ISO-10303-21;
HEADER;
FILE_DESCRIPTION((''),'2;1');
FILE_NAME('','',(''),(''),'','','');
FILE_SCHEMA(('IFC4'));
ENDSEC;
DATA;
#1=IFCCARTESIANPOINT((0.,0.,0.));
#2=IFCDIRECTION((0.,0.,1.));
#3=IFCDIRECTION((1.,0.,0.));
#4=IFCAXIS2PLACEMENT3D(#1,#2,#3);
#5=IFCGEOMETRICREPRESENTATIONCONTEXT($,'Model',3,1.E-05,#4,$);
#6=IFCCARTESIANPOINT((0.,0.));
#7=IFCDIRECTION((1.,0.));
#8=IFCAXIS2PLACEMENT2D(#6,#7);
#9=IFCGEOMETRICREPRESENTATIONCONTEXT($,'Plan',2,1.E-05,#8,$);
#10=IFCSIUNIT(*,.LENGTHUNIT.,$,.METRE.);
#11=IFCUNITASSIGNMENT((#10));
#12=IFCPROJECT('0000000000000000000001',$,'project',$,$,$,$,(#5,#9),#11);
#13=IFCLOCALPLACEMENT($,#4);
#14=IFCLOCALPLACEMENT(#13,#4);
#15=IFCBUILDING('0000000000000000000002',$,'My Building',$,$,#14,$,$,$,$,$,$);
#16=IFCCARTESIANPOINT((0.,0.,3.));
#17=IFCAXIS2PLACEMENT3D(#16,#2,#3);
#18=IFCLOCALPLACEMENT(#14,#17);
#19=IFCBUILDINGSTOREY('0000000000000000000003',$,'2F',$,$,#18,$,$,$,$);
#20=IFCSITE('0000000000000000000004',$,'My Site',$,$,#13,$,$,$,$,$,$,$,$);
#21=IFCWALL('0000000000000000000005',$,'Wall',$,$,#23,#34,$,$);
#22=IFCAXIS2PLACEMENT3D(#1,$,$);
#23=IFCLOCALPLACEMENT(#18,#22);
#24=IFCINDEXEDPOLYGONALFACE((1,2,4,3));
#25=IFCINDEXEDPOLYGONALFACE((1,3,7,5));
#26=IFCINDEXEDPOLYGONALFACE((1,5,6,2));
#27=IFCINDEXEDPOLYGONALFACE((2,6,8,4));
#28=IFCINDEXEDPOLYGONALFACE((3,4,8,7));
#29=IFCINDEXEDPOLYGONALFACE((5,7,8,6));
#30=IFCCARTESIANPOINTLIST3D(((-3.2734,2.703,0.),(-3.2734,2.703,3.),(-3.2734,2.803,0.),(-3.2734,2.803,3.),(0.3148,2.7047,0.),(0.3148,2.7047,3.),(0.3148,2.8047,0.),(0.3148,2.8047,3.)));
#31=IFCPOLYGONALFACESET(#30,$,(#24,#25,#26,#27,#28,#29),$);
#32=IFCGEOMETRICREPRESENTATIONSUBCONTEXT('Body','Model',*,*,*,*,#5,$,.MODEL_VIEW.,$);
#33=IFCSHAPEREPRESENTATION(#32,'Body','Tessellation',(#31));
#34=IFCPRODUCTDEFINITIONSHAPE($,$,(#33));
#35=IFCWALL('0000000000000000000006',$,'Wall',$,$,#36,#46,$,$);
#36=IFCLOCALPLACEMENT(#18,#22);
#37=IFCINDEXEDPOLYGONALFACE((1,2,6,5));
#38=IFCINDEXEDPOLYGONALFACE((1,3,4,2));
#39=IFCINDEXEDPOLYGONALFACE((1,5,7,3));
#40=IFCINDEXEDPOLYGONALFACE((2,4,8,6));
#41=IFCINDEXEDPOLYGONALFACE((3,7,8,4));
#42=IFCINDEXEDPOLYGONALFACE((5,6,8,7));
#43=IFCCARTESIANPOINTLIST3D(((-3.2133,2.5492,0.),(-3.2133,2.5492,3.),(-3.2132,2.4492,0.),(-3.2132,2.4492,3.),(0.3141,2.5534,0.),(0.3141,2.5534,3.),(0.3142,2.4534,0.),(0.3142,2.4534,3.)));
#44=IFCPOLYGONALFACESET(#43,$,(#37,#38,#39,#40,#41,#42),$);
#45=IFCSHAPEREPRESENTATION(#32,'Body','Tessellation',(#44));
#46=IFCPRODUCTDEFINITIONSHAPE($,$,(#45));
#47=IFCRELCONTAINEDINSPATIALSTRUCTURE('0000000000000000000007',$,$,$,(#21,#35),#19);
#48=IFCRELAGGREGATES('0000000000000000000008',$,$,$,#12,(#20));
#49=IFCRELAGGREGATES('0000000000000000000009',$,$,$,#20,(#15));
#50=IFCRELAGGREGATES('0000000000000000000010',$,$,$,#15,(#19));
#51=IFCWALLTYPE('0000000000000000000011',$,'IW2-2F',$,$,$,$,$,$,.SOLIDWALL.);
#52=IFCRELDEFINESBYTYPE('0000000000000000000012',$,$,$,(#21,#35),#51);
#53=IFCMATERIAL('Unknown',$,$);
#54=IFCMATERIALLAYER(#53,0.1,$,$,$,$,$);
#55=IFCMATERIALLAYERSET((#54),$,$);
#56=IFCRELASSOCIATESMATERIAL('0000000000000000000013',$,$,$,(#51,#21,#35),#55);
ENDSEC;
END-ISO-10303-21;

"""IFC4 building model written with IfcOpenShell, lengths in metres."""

from ifc_helpers import new_model, si_unit, frame, origin_with_axes, origin_2d_with_axis, place, context, subcontext, project, spatial, line, indexed_curve, outline, extrude, material, layer, layer_set, layer_usage, type_object, element, save


model = new_model("IFC4")

# Units and contexts
model_context = context("Model", 3, precision=1e-05, world=origin_with_axes())
plan_context = context("Plan", 2, precision=1e-05, world=origin_2d_with_axis())
body_context_1 = subcontext(model_context, "Body", "Model", "MODEL_VIEW")
ifc_project = project(units=[si_unit("LENGTHUNIT", "METRE")], contexts=[model_context, plan_context])

# Site, building, storey
site_placement = place(None, origin_with_axes())
site = spatial("IfcSite", under=ifc_project, at=site_placement, Name="My Site")
building_placement = place(site_placement, origin_with_axes())
building = spatial("IfcBuilding", under=site, at=building_placement, Name="My Building")
storey_placement = place(building_placement, frame((0.0, 0.0, 3.0), z_axis=(0.0, 0.0, 1.0), x_axis=(1.0, 0.0, 0.0)))
storey = spatial("IfcBuildingStorey", under=building, at=storey_placement, Name="2F")

# Shared definitions
ifc_material = material(Name="Unknown")

# Walls
ifc_layer_1 = layer(ifc_material, 0.1)
ifc_layer_set_1 = layer_set([ifc_layer_1])
ifc_layer_usage_1 = layer_usage(ifc_layer_set_1, "AXIS2", "POSITIVE", 0.0)
wall_type_1 = type_object("IfcWallType", Name="IW2-2F", PredefinedType="SOLIDWALL", material=ifc_layer_set_1)
wall_1_placement = place(storey_placement, frame((-3.2734, 2.703, 0.0), z_axis=(0.0, 0.0, 1.0), x_axis=(1.0, 0.000495, 0.0)))
element("IfcWall", 1, at=wall_1_placement, inside=storey, type_object=wall_type_1, material=ifc_layer_usage_1, Name="Wall", context=body_context_1, shape_type="SweptSolid", body=[
    extrude(outline(indexed_curve([(0.0, 0.0), (0.0, 0.1), (3.5882, 0.1), (3.5882, 0.0)], segments=[line(1, 2, 3, 4, 1)])), origin_with_axes(), (0.0, 0.0, 1.0), 3.0),
])
ifc_layer_usage_2 = layer_usage(ifc_layer_set_1, "AXIS2", "POSITIVE", 0.0)
wall_2_placement = place(storey_placement, frame((-3.2132, 2.4492, 0.0), z_axis=(0.0, 0.0, 1.0), x_axis=(0.999999, 0.001175, 0.0)))
element("IfcWall", 2, at=wall_2_placement, inside=storey, type_object=wall_type_1, material=ifc_layer_usage_2, Name="Wall", context=body_context_1, shape_type="SweptSolid", body=[
    extrude(outline(indexed_curve([(0.0, 0.0), (0.0, 0.1), (3.5275, 0.1), (3.5275, 0.0)], segments=[line(1, 2, 3, 4, 1)])), origin_with_axes(), (0.0, 0.0, 1.0), 3.0),
])

save(model, "model.ifc")
